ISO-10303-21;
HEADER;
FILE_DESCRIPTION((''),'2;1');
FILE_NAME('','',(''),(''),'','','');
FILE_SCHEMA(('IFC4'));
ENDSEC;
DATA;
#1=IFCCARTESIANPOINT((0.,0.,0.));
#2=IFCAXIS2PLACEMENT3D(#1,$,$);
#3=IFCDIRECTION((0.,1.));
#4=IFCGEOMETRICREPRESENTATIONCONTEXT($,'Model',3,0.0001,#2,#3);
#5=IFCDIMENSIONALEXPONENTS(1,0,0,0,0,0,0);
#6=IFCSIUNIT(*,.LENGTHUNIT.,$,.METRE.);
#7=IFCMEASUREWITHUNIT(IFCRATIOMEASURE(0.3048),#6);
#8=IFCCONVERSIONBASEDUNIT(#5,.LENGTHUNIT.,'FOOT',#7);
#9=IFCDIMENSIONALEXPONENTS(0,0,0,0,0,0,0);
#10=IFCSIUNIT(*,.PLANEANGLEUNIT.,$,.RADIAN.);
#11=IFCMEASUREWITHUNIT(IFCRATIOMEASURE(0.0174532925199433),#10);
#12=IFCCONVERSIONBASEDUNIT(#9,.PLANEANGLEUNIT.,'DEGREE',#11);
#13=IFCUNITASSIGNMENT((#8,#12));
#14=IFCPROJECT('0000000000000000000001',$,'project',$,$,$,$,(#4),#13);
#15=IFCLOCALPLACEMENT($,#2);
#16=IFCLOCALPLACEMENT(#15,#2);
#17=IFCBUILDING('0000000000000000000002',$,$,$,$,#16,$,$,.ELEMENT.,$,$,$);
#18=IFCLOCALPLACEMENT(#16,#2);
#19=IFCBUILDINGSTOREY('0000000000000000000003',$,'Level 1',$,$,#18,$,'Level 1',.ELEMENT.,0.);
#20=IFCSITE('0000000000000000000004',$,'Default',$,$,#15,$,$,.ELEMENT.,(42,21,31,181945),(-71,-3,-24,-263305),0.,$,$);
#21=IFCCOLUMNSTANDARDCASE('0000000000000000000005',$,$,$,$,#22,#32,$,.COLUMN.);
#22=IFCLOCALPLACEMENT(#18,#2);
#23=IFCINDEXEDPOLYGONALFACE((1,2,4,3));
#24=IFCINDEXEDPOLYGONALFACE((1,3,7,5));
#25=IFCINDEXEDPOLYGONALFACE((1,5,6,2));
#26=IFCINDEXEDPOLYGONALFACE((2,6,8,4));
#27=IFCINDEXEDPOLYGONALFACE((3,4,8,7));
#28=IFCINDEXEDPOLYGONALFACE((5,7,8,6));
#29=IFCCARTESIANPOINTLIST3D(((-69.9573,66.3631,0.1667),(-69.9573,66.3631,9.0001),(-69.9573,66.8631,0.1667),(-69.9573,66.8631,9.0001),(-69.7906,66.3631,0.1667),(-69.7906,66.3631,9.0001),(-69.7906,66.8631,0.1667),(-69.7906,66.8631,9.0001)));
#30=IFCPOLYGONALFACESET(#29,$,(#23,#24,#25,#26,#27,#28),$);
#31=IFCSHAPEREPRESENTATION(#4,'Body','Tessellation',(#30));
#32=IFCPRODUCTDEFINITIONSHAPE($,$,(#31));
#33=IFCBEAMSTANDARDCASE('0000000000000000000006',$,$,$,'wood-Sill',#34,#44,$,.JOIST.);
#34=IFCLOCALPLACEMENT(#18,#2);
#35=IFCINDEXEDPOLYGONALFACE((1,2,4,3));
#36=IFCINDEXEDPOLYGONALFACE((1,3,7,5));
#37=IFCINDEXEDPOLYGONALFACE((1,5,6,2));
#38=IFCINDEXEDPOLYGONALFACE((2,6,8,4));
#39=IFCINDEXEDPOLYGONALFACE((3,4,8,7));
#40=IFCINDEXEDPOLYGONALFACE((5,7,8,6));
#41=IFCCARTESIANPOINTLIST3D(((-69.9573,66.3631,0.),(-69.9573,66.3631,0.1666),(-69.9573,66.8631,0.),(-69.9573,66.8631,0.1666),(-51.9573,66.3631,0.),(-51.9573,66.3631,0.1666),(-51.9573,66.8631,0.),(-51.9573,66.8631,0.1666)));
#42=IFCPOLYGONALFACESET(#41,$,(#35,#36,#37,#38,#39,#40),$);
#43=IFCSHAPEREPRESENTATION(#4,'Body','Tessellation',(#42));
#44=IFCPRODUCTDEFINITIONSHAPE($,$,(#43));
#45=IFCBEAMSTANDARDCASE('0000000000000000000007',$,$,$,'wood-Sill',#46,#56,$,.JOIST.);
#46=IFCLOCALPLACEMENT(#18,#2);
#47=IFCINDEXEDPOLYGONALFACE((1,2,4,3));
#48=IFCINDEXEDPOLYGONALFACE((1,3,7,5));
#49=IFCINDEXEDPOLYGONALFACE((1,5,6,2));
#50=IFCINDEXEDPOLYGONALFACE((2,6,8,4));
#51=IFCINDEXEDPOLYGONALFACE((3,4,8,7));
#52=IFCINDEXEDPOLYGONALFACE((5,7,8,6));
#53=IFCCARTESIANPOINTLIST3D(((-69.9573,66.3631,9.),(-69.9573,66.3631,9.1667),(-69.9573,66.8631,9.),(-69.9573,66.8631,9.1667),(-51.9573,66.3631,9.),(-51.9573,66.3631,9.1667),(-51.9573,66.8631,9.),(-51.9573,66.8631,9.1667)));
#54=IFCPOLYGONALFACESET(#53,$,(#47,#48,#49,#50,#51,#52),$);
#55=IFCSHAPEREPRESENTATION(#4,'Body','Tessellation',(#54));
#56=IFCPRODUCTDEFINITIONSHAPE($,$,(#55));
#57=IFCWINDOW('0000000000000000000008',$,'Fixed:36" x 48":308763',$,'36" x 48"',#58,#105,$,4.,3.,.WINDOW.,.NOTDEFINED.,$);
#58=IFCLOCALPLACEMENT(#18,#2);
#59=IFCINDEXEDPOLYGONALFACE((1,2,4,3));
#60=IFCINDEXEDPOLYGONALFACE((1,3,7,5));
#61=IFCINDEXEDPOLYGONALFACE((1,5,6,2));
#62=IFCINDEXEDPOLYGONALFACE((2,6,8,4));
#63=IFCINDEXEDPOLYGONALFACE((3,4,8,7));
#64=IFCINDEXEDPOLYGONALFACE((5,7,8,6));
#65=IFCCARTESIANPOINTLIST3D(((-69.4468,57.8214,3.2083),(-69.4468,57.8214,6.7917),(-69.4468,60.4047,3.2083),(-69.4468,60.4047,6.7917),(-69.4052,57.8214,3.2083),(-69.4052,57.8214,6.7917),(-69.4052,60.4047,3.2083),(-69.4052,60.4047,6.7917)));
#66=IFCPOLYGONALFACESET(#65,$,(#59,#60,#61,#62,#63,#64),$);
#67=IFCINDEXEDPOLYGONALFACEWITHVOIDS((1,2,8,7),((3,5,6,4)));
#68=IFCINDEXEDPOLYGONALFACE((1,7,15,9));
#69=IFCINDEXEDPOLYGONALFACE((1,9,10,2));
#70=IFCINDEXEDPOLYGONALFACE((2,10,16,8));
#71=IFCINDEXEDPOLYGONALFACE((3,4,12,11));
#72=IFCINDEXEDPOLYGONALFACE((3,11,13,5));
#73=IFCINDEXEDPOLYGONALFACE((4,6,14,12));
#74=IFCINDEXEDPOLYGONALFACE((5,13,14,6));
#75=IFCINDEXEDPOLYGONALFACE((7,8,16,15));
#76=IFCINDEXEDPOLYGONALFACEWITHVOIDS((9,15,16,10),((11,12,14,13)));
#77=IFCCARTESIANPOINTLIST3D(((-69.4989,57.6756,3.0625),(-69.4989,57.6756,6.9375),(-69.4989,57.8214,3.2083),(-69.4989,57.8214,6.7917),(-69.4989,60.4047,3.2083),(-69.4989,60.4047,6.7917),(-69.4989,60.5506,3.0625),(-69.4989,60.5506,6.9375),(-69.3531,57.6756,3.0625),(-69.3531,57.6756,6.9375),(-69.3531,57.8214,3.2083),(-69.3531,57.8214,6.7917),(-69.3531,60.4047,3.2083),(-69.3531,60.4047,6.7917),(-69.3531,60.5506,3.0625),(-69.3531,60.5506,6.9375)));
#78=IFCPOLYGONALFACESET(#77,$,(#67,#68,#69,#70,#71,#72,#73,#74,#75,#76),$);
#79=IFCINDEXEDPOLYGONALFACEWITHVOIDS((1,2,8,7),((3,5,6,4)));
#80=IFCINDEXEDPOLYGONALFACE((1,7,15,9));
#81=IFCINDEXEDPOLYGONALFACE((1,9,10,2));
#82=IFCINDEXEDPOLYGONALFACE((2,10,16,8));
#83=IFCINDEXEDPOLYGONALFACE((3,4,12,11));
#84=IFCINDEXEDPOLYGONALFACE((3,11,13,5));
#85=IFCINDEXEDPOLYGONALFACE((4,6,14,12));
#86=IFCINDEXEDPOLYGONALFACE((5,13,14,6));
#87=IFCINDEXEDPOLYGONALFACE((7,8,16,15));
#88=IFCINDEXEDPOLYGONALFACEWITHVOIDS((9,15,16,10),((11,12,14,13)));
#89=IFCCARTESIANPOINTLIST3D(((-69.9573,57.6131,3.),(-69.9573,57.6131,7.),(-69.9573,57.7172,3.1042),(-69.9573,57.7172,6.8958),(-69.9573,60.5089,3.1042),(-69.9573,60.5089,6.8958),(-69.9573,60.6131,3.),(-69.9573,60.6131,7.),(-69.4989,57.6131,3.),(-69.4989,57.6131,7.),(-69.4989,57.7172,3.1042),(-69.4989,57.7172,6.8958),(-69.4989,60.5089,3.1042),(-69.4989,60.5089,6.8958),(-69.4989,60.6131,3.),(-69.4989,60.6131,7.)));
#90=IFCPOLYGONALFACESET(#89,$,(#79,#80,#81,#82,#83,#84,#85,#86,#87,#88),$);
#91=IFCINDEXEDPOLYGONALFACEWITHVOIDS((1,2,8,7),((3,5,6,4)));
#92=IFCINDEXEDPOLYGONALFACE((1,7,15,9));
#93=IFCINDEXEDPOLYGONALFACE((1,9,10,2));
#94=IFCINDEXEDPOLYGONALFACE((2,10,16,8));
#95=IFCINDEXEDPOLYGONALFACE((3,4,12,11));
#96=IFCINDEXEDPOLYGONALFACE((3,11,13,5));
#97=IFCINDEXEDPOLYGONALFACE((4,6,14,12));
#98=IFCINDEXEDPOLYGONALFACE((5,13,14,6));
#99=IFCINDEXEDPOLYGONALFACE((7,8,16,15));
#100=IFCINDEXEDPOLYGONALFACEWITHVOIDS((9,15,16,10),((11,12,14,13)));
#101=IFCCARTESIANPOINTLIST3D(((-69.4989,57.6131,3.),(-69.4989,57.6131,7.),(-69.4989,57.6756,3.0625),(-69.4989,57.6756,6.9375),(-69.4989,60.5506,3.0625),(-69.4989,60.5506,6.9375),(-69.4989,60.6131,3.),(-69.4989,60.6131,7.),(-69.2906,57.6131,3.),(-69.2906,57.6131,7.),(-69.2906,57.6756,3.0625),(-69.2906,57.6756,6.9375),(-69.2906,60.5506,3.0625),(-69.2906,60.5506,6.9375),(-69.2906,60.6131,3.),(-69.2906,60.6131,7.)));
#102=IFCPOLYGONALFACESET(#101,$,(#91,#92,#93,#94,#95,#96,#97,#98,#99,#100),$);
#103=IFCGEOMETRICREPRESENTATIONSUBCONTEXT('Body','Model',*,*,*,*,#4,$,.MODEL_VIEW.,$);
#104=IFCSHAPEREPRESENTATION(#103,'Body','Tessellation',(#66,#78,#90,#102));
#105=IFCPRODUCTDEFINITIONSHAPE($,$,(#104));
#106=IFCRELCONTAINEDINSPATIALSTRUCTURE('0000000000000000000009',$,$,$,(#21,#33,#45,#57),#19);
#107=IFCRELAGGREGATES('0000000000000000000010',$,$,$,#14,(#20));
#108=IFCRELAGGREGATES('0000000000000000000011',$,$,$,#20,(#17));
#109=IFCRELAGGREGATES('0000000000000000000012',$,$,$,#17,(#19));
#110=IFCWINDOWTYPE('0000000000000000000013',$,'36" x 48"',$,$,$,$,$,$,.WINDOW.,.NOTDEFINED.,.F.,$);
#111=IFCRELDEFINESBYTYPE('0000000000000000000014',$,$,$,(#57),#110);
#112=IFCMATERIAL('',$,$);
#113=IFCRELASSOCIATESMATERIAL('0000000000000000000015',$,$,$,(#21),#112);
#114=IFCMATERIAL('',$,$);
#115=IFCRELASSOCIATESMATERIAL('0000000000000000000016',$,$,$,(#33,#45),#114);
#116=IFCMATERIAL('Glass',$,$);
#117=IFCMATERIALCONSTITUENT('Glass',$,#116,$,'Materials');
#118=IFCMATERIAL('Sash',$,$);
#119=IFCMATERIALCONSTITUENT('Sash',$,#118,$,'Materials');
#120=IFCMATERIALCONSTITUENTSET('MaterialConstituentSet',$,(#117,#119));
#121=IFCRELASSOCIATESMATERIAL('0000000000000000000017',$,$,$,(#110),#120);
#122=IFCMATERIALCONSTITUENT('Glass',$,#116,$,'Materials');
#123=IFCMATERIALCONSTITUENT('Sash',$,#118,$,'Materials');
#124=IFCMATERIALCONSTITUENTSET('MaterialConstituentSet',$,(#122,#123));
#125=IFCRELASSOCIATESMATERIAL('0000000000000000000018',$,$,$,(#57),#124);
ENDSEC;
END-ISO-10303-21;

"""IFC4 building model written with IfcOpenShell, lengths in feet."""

from ifc_helpers import new_model, entity, si_unit, converted_unit, direction, frame, frame_2d, origin, origin_with_axes, place, context, subcontext, project, spatial, polyline, rectangle, outline, extrude, source, transform, mapped, material, constituent, constituent_set, type_object, type_shapes, element, save


model = new_model("IFC4")

# Units and contexts
model_context = context("Model", 3, precision=0.0001, world=origin(), true_north=direction((0.0, 1.0)))
body_context = subcontext(model_context, "Body", "Model", "MODEL_VIEW")
ifc_project = project(units=[converted_unit("LENGTHUNIT", "FOOT", entity("IfcRatioMeasure", 0.3048), si_unit("LENGTHUNIT", "METRE"), dimensions=[1, 0, 0, 0, 0, 0, 0]), converted_unit("PLANEANGLEUNIT", "DEGREE", entity("IfcRatioMeasure", 0.0174532925199433), si_unit("PLANEANGLEUNIT", "RADIAN"), dimensions=[0, 0, 0, 0, 0, 0, 0])], contexts=[model_context])

# Site, building, storey
site_placement = place(None, origin())
site = spatial("IfcSite", under=ifc_project, at=site_placement, Name="Default", CompositionType="ELEMENT", RefLatitude=(42, 21, 31, 181945), RefLongitude=(-71, -3, -24, -263305), RefElevation=0.0)
building_placement = place(site_placement, origin())
building = spatial("IfcBuilding", under=site, at=building_placement, CompositionType="ELEMENT")
storey_placement = place(building_placement, origin())
storey = spatial("IfcBuildingStorey", under=building, at=storey_placement, Name="Level 1", LongName="Level 1", CompositionType="ELEMENT", Elevation=0.0)

# Column
ifc_material_1 = material(Name="")
placement_1 = place(storey_placement, frame((-69.9573, 66.6131, 0.0)))
for number, where, z_axis, x_axis in (
    (1, (0.0833, 0.0, 0.1667), (0.0, 0.0, 1.0), (1.0, 0.0, 0.0)),
):
    element("IfcColumnStandardCase", number, at=place(placement_1, frame(where, z_axis=z_axis, x_axis=x_axis)), inside=storey, material=ifc_material_1, PredefinedType="COLUMN", context=model_context, shape_type="SweptSolid", body=[
        extrude(rectangle(XDim=0.1667, YDim=0.5), origin(), (0.0, 0.0, 1.0), 8.8334),
    ])
placement_2 = place(storey_placement, frame((-69.6239, 19.7797, 0.0), z_axis=(0.0, 0.0, 1.0), x_axis=(0.0, 1.0, 0.0)))

# Beams
ifc_material_2 = material(Name="")
for number, where, z_axis, x_axis in (
    (2, (0.0, 0.0, 0.0833), (1.0, 0.0, 0.0), (0.0, 0.0, 1.0)),
    (3, (0.0, 0.0, 9.0834), (1.0, 0.0, 0.0), (0.0, 0.0, 1.0)),
):
    element("IfcBeamStandardCase", number, at=place(placement_1, frame(where, z_axis=z_axis, x_axis=x_axis)), inside=storey, material=ifc_material_2, ObjectType="wood-Sill", PredefinedType="JOIST", context=model_context, shape_type="SweptSolid", body=[
        extrude(rectangle(XDim=0.1667, YDim=0.5), origin_with_axes(), (0.0, 0.0, 1.0), 18.0),
    ])

# Window
ifc_material_3 = material(Name="Glass")
ifc_constituent_1 = constituent(ifc_material_3, Name="Glass", Category="Materials")
ifc_material_4 = material(Name="Sash")
ifc_constituent_2 = constituent(ifc_material_4, Name="Sash", Category="Materials")
ifc_constituent_set_1 = constituent_set(constituents=[ifc_constituent_1, ifc_constituent_2], Name="MaterialConstituentSet")
ifc_constituent_3 = constituent(ifc_material_3, Name="Glass", Category="Materials")
ifc_constituent_4 = constituent(ifc_material_4, Name="Sash", Category="Materials")
ifc_constituent_set_2 = constituent_set(constituents=[ifc_constituent_3, ifc_constituent_4], Name="MaterialConstituentSet")
window_type = type_object("IfcWindowType", Name="36\" x 48\"", ParameterTakesPrecedence=False, PartitioningType="NOTDEFINED", PredefinedType="WINDOW", material=ifc_constituent_set_2)
shared_shape = source(origin(), body_context, "Body", "SweptSolid", [
    extrude(rectangle(XDim=0.0417, YDim=2.5833, at=frame_2d((0.0, 0.0), x_axis=(1.0, 0.0))), frame((1.5, 0.5312, 0.2083), z_axis=(0.0, 0.0, 1.0), x_axis=(0.0, 1.0, 0.0)), (0.0, 0.0, 1.0), 3.5833),
    extrude(outline(polyline([(-1.4375, -1.9375), (1.4375, -1.9375), (1.4375, 1.9375), (-1.4375, 1.9375), (-1.4375, -1.9375)]), holes=[polyline([(-1.2917, -1.7917), (-1.2917, 1.7917), (1.2917, 1.7917), (1.2917, -1.7917), (-1.2917, -1.7917)])]), frame((1.5, 0.4583, 2.0), z_axis=(0.0, 1.0, 0.0), x_axis=(1.0, 0.0, 0.0)), (0.0, 0.0, 1.0), 0.1458),
    extrude(outline(polyline([(-1.5, -2.0), (1.5, -2.0), (1.5, 2.0), (-1.5, 2.0), (-1.5, -2.0)]), holes=[polyline([(-1.3958, -1.8958), (-1.3958, 1.8958), (1.3958, 1.8958), (1.3958, -1.8958), (-1.3958, -1.8958)])]), frame((1.5, 0.0, 2.0), z_axis=(0.0, 1.0, 0.0), x_axis=(1.0, 0.0, 0.0)), (0.0, 0.0, 1.0), 0.4583),
    extrude(outline(polyline([(-2.0, -1.5), (2.0, -1.5), (2.0, 1.5), (-2.0, 1.5), (-2.0, -1.5)]), holes=[polyline([(-1.9375, -1.4375), (-1.9375, 1.4375), (1.9375, 1.4375), (1.9375, -1.4375), (-1.9375, -1.4375)])]), frame((1.5, 0.4583, 2.0), z_axis=(0.0, 1.0, 0.0), x_axis=(0.0, 0.0, -1.0)), (0.0, 0.0, 1.0), 0.2083),
])
type_shapes(window_type, [shared_shape])
placement_3 = place(placement_2, frame((40.8333, 0.3333, 3.0)))
window_placement = place(placement_3, frame((0.0, 0.0, 0.0), z_axis=(0.0, 0.0, 1.0), x_axis=(-1.0, 0.0, 0.0)))
element("IfcWindow", 4, at=window_placement, inside=storey, type_object=window_type, material=ifc_constituent_set_1, Name="Fixed:36\" x 48\":308763", ObjectType="36\" x 48\"", OverallHeight=4.0, OverallWidth=3.0, PartitioningType="NOTDEFINED", PredefinedType="WINDOW", context=body_context, shape_type="MappedRepresentation", body=[
    mapped(shared_shape, transform((0.0, 0.0, 0.0), scale=1.0)),
])

save(model, "model.ifc")
